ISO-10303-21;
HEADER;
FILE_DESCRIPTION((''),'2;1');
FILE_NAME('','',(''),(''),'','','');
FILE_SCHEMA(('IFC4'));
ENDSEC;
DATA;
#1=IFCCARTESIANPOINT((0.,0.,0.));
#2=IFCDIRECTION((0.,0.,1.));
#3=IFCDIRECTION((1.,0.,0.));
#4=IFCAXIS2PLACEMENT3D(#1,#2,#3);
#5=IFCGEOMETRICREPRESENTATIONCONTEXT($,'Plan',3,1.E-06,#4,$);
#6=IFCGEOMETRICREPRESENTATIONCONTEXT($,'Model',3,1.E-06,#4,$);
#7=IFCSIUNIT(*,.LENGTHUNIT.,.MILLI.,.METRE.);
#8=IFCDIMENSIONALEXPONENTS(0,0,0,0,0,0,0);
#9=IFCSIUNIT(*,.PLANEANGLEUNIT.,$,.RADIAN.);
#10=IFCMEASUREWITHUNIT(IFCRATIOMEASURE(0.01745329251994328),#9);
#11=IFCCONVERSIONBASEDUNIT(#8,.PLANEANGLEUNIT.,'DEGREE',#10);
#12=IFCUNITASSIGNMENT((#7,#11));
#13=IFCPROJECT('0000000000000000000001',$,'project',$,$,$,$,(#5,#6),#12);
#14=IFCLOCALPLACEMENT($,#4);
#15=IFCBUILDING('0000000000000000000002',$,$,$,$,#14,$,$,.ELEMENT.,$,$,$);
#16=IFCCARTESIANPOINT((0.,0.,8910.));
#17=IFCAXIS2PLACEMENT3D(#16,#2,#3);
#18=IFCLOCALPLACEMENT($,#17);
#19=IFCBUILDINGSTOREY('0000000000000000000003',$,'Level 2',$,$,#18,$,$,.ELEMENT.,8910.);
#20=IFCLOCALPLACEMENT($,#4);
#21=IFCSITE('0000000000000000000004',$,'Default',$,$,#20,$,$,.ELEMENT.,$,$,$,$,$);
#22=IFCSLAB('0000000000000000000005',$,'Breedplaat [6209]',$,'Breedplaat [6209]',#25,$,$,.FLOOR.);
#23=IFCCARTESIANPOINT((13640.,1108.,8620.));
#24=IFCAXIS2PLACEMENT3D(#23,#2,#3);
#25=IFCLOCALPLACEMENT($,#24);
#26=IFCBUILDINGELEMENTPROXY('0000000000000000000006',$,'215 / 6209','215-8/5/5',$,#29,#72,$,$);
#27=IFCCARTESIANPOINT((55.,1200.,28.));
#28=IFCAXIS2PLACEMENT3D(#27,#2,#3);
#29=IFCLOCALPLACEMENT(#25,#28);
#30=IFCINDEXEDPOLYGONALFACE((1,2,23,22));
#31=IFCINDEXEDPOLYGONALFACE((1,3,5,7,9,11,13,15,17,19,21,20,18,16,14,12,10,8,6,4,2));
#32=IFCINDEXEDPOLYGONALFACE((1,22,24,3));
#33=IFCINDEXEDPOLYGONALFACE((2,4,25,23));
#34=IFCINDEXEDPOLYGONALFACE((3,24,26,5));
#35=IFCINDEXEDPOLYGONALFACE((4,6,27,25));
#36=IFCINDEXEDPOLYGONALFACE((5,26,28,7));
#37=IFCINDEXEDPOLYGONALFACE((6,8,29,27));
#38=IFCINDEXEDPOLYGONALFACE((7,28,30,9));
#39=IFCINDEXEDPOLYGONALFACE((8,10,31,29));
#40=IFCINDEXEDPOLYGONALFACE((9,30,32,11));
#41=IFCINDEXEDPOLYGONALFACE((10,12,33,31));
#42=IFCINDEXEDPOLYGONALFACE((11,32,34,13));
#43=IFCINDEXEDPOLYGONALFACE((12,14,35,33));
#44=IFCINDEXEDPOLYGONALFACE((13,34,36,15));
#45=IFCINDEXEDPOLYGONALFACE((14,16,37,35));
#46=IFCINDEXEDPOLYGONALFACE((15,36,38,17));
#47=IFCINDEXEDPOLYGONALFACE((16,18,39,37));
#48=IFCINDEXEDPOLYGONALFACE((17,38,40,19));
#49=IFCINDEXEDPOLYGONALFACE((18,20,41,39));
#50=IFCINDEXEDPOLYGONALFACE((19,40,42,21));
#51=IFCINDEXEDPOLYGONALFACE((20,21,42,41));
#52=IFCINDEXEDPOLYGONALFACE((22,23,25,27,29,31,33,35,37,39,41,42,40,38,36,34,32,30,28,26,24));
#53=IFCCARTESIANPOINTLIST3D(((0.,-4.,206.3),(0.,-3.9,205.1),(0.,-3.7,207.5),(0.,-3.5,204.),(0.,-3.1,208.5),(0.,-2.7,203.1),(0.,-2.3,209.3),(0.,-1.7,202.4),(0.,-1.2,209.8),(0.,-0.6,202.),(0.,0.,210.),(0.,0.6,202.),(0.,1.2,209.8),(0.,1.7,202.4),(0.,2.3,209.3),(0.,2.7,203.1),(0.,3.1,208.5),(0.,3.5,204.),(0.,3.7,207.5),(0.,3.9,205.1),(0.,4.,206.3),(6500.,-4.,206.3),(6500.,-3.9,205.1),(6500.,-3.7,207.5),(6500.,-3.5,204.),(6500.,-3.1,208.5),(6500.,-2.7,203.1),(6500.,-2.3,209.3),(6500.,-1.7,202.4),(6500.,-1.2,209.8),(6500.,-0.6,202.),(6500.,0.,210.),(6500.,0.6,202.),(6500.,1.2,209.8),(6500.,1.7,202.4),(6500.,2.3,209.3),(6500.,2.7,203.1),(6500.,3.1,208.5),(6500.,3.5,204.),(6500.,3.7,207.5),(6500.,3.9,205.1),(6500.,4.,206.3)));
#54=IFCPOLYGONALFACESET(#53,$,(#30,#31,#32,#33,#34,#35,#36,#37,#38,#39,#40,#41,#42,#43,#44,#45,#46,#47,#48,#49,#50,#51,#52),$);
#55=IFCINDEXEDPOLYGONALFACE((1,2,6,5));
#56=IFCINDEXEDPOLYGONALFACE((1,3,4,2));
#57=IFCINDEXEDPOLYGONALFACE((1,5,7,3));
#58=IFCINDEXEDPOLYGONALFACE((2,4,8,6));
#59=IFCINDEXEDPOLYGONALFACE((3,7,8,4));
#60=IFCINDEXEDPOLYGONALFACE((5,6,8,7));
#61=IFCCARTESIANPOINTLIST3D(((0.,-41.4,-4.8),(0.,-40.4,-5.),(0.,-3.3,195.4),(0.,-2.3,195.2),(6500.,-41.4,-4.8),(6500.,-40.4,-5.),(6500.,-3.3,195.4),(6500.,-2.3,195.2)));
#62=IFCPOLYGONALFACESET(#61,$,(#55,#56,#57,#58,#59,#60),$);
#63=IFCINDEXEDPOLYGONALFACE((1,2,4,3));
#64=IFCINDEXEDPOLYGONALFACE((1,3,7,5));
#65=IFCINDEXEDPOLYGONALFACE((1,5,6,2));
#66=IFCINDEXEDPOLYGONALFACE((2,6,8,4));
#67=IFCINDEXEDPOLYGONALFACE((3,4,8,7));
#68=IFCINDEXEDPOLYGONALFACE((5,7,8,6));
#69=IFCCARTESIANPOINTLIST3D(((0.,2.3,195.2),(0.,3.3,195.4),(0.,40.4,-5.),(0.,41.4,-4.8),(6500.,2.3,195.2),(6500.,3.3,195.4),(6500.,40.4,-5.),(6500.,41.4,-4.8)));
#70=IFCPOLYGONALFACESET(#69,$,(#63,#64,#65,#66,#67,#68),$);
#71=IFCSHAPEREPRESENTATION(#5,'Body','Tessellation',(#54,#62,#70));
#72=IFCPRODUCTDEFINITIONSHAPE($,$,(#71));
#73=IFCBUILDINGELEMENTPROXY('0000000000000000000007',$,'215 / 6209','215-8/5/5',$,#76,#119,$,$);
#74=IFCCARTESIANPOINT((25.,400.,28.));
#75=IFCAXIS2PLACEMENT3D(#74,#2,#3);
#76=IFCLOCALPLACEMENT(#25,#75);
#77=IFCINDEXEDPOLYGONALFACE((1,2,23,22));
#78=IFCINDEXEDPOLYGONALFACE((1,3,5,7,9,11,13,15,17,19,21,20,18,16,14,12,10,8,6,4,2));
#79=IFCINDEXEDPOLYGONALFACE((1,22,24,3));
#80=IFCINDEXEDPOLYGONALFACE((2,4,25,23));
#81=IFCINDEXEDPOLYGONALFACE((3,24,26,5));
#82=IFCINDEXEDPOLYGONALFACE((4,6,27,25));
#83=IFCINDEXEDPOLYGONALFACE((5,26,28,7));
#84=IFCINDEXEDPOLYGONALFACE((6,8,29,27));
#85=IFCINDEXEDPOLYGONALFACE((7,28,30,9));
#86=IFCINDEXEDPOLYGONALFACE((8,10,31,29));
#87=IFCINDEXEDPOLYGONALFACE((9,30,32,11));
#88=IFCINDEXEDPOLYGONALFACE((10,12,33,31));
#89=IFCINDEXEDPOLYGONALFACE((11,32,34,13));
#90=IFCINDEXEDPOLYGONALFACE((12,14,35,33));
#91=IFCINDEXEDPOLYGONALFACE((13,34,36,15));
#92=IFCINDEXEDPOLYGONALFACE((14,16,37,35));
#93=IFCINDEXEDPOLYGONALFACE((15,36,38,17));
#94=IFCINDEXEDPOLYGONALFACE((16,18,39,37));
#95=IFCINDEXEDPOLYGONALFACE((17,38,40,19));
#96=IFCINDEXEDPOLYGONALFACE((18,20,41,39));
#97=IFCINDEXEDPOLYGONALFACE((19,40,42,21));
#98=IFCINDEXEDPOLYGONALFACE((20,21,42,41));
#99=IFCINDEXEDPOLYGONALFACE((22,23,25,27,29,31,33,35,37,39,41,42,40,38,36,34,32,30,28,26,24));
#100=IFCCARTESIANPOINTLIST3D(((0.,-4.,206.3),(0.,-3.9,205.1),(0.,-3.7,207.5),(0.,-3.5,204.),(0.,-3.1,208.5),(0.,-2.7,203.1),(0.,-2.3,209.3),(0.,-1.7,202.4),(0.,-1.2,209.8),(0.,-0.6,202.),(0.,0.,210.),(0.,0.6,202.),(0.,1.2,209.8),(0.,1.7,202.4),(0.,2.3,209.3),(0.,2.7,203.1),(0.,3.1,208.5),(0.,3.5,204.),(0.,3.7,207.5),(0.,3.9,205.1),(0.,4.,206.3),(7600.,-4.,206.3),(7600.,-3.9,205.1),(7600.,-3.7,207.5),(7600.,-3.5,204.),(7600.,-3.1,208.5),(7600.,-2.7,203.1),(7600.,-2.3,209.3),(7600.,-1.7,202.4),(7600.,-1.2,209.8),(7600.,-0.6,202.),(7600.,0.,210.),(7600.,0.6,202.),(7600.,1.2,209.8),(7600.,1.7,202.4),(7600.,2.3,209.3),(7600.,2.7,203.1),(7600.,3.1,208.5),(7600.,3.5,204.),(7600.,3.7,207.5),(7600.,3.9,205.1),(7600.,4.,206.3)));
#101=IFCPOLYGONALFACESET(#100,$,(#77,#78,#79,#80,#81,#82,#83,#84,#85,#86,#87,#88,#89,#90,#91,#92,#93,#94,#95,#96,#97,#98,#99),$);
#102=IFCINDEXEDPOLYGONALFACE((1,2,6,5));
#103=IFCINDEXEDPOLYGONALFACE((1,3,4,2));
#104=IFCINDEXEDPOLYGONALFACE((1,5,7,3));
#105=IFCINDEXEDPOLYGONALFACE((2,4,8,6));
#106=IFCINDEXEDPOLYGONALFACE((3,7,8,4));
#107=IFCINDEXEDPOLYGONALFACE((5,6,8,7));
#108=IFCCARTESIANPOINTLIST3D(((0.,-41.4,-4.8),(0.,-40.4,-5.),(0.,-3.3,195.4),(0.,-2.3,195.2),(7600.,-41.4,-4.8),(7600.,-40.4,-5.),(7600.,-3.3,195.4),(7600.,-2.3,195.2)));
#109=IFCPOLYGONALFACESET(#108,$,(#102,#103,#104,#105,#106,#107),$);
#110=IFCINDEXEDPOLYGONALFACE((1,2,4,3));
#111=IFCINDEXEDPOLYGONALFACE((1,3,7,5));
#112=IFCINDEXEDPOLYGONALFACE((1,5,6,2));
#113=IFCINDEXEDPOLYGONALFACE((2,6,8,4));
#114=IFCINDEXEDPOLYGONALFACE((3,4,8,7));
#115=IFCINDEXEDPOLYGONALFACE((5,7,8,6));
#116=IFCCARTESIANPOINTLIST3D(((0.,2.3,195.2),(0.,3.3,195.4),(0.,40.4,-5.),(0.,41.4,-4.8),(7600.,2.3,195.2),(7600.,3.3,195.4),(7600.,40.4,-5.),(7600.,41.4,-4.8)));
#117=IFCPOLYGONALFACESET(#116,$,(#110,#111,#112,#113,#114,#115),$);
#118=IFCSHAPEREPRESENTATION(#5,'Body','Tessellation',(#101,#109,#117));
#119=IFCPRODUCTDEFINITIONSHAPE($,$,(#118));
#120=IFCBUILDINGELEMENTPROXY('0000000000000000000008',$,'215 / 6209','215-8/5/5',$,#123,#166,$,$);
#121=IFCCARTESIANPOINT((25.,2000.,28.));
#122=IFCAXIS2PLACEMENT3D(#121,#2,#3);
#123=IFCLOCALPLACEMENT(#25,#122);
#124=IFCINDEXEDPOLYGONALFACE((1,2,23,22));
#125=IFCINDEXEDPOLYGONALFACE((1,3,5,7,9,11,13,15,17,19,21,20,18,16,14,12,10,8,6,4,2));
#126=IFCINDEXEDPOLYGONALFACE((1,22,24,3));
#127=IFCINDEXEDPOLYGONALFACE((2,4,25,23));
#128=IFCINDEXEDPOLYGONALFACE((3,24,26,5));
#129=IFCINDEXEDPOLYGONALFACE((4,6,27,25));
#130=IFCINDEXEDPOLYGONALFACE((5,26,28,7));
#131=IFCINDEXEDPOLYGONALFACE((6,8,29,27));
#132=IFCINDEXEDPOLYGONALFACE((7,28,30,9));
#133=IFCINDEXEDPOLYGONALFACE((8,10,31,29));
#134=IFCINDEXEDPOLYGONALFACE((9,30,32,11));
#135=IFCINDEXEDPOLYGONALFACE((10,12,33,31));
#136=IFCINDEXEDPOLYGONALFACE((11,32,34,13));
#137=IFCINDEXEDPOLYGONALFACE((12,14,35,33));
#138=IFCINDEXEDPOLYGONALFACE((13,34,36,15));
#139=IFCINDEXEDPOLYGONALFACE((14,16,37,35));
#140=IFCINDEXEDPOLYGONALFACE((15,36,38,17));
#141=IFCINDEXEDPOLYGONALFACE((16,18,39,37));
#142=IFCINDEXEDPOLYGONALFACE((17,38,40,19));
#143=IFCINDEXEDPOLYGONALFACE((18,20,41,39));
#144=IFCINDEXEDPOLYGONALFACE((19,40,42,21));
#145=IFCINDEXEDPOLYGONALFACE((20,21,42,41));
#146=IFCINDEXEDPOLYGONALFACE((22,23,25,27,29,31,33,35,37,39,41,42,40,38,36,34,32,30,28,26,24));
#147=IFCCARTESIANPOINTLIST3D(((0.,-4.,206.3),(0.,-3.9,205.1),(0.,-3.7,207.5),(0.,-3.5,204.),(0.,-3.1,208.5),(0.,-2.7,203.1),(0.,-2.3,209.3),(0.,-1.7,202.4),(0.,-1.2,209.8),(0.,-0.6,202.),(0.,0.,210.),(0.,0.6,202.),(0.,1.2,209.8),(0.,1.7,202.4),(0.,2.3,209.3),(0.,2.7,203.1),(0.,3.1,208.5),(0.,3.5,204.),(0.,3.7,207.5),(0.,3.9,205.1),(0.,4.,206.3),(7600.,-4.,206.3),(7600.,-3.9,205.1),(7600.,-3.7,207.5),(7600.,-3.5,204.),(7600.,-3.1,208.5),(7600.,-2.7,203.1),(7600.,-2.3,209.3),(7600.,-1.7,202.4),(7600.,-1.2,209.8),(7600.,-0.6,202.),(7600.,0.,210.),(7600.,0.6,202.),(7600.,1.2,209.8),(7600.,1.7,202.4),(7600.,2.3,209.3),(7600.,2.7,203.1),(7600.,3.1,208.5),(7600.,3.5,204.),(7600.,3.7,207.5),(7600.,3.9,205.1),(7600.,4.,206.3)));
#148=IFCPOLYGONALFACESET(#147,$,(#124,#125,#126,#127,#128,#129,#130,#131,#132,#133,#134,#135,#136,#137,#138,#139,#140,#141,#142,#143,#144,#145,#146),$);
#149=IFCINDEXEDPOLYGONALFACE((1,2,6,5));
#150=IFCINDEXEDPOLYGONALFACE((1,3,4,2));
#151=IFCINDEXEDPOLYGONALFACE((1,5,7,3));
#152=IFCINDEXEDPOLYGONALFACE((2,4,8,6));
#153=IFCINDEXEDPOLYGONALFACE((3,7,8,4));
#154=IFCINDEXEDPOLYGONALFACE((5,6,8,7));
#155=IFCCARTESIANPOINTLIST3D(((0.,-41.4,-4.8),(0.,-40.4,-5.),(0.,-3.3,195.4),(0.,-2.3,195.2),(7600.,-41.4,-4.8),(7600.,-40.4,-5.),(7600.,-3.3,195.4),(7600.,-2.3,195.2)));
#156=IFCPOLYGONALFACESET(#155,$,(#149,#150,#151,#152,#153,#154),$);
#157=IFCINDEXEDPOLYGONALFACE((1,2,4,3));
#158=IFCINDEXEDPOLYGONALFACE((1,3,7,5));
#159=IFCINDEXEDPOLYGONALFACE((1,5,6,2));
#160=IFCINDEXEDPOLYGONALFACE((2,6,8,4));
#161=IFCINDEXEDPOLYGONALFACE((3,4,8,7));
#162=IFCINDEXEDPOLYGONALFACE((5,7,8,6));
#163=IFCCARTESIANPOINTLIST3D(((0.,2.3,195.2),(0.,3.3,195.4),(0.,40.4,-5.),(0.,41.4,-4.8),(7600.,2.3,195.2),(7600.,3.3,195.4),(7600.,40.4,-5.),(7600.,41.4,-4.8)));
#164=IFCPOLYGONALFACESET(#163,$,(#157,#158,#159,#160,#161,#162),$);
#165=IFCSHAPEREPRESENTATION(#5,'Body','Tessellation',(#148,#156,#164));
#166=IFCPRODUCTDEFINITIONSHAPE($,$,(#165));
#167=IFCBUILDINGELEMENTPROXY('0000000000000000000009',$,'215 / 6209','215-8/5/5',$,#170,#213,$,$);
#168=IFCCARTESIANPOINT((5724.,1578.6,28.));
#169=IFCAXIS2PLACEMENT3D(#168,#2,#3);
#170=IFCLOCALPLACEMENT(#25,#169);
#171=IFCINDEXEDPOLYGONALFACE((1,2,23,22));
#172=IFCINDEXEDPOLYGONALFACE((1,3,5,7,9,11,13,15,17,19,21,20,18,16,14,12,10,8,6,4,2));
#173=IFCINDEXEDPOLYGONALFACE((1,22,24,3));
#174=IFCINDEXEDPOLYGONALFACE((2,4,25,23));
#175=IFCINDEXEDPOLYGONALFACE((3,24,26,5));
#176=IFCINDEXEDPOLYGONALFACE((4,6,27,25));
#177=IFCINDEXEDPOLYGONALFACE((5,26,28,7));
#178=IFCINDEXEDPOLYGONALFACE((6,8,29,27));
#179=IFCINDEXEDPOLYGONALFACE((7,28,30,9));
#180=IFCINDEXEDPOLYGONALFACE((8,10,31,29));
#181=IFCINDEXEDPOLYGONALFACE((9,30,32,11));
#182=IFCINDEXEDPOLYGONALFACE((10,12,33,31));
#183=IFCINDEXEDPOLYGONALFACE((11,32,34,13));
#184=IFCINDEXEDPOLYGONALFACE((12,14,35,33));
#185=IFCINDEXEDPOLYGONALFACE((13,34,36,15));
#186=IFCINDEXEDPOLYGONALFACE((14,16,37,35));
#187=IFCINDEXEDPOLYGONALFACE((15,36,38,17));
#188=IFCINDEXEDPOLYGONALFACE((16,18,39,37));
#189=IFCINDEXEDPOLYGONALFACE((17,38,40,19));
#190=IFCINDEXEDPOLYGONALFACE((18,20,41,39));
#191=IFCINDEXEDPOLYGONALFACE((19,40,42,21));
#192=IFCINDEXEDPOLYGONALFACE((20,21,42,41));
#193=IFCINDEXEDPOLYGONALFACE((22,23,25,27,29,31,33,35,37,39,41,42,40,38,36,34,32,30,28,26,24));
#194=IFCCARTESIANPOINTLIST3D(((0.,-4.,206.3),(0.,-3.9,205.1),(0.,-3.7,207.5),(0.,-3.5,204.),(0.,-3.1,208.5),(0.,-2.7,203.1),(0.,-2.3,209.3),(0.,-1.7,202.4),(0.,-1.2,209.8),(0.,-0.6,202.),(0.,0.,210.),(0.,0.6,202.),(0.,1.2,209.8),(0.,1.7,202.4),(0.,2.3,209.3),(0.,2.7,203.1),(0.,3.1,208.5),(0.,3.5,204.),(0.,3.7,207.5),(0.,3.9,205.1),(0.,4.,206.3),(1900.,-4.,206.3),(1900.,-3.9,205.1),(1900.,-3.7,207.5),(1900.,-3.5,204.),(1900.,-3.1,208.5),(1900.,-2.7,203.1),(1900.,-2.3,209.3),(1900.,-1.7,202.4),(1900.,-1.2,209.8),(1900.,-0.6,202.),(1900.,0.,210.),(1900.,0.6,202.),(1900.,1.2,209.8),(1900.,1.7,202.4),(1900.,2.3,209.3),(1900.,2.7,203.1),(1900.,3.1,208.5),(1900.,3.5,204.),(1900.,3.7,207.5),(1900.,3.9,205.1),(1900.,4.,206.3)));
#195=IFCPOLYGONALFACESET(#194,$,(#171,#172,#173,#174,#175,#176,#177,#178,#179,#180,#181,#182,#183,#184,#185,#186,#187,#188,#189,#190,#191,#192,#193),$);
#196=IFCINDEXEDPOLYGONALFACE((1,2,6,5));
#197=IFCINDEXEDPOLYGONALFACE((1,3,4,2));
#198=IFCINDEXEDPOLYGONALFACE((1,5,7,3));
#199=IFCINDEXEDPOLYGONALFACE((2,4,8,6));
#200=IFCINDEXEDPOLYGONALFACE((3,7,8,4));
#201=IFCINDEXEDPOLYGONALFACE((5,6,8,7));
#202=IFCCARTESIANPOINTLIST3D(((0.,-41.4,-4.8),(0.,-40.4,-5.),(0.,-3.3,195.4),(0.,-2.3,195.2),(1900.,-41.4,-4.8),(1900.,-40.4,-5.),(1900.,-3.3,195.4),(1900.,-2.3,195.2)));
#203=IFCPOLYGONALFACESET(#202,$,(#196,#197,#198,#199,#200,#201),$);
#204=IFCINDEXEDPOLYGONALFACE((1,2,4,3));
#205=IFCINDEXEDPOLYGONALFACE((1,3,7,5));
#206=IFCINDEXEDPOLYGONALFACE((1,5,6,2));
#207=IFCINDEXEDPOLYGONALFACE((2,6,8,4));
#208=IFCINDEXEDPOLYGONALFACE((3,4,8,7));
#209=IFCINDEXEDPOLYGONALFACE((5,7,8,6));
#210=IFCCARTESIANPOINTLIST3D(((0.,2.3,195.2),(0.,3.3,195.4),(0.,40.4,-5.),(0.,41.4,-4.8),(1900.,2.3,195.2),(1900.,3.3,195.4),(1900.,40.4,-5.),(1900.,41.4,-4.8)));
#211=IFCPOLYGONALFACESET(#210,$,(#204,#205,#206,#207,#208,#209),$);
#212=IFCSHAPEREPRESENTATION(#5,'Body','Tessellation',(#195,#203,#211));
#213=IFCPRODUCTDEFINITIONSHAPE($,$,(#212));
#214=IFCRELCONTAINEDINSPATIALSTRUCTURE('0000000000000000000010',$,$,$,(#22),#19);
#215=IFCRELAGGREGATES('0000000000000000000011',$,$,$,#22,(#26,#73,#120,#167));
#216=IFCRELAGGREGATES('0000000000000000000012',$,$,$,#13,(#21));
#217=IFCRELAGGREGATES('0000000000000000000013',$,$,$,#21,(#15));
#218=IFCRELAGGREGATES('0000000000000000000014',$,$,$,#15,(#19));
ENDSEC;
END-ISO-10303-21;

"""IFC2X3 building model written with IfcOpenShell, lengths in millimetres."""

from ifc_helpers import new_model, entity, si_unit, converted_unit, frame, origin_with_axes, origin_2d_with_axis, place, context, project, spatial, rectangle, circle, extrude, element, aggregate, save


model = new_model("IFC2X3")

# Units and contexts
plan_context = context("Plan", 3, precision=1e-06, world=origin_with_axes())
model_context = context("Model", 3, precision=1e-06, world=origin_with_axes())
ifc_project = project(units=[si_unit("LENGTHUNIT", "METRE", prefix="MILLI"), converted_unit("PLANEANGLEUNIT", "DEGREE", entity("IfcRatioMeasure", 0.01745329251994328), si_unit("PLANEANGLEUNIT", "RADIAN"), dimensions=[0, 0, 0, 0, 0, 0, 0])], contexts=[plan_context, model_context])

# Site, building, storey
site_placement = place(None, origin_with_axes())
site = spatial("IfcSite", under=ifc_project, at=site_placement, Name="Default", CompositionType="ELEMENT")
building_placement = place(None, origin_with_axes())
building = spatial("IfcBuilding", under=site, at=building_placement, CompositionType="ELEMENT")
storey_placement = place(None, frame((0.0, 0.0, 8910.0), z_axis=(0.0, 0.0, 1.0), x_axis=(1.0, 0.0, 0.0)))
storey = spatial("IfcBuildingStorey", under=building, at=storey_placement, Name="Level 2", CompositionType="ELEMENT", Elevation=8910.0)

# Slab, building element proxies
slab_1_placement = place(None, frame((13640.0, 1108.0, 8620.0), z_axis=(0.0, 0.0, 1.0), x_axis=(1.0, 0.0, 0.0)))
slab_1 = element("IfcSlab", 1, at=slab_1_placement, inside=storey, Name="Breedplaat [6209]", ObjectType="Breedplaat [6209]", PredefinedType="FLOOR")
proxy_1_placement = place(slab_1_placement, frame((55.0, 1200.0, 28.0), z_axis=(0.0, 0.0, 1.0), x_axis=(1.0, 0.0, 0.0)))
proxy_1 = element("IfcBuildingElementProxy", 2, at=proxy_1_placement, Name="215 / 6209", Description="215-8/5/5", context=plan_context, shape_type="SweptSolid", body=[
    extrude(circle(Radius=4.0, at=origin_2d_with_axis()), frame((0.0, 0.0, 206.0), z_axis=(1.0, 0.0, 0.0), x_axis=(0.0, 0.0, 1.0)), (0.0, 0.0, 1.0), 6500.0),
    extrude(rectangle(XDim=203.8, YDim=1.0, at=origin_2d_with_axis()), frame((0.0, -21.9, 95.2), z_axis=(1.0, 0.0, 0.0), x_axis=(0.0, 0.187112, 0.982339)), (0.0, 0.0, 1.0), 6500.0),
    extrude(rectangle(XDim=203.8, YDim=1.0, at=origin_2d_with_axis()), frame((0.0, 21.9, 95.2), z_axis=(1.0, 0.0, 0.0), x_axis=(0.0, -0.187112, 0.982339)), (0.0, 0.0, 1.0), 6500.0),
])
proxy_2_placement = place(slab_1_placement, frame((25.0, 400.0, 28.0), z_axis=(0.0, 0.0, 1.0), x_axis=(1.0, 0.0, 0.0)))
proxy_2 = element("IfcBuildingElementProxy", 3, at=proxy_2_placement, Name="215 / 6209", Description="215-8/5/5", context=plan_context, shape_type="SweptSolid", body=[
    extrude(circle(Radius=4.0, at=origin_2d_with_axis()), frame((0.0, 0.0, 206.0), z_axis=(1.0, 0.0, 0.0), x_axis=(0.0, 0.0, 1.0)), (0.0, 0.0, 1.0), 7600.0),
    extrude(rectangle(XDim=203.8, YDim=1.0, at=origin_2d_with_axis()), frame((0.0, -21.9, 95.2), z_axis=(1.0, 0.0, 0.0), x_axis=(0.0, 0.187112, 0.982339)), (0.0, 0.0, 1.0), 7600.0),
    extrude(rectangle(XDim=203.8, YDim=1.0, at=origin_2d_with_axis()), frame((0.0, 21.9, 95.2), z_axis=(1.0, 0.0, 0.0), x_axis=(0.0, -0.187112, 0.982339)), (0.0, 0.0, 1.0), 7600.0),
])
proxy_3_placement = place(slab_1_placement, frame((25.0, 2000.0, 28.0), z_axis=(0.0, 0.0, 1.0), x_axis=(1.0, 0.0, 0.0)))
proxy_3 = element("IfcBuildingElementProxy", 4, at=proxy_3_placement, Name="215 / 6209", Description="215-8/5/5", context=plan_context, shape_type="SweptSolid", body=[
    extrude(circle(Radius=4.0, at=origin_2d_with_axis()), frame((0.0, 0.0, 206.0), z_axis=(1.0, 0.0, 0.0), x_axis=(0.0, 0.0, 1.0)), (0.0, 0.0, 1.0), 7600.0),
    extrude(rectangle(XDim=203.8, YDim=1.0, at=origin_2d_with_axis()), frame((0.0, -21.9, 95.2), z_axis=(1.0, 0.0, 0.0), x_axis=(0.0, 0.187112, 0.982339)), (0.0, 0.0, 1.0), 7600.0),
    extrude(rectangle(XDim=203.8, YDim=1.0, at=origin_2d_with_axis()), frame((0.0, 21.9, 95.2), z_axis=(1.0, 0.0, 0.0), x_axis=(0.0, -0.187112, 0.982339)), (0.0, 0.0, 1.0), 7600.0),
])
proxy_4_placement = place(slab_1_placement, frame((5724.0, 1578.6, 28.0), z_axis=(0.0, 0.0, 1.0), x_axis=(1.0, 0.0, 0.0)))
proxy_4 = element("IfcBuildingElementProxy", 5, at=proxy_4_placement, Name="215 / 6209", Description="215-8/5/5", context=plan_context, shape_type="SweptSolid", body=[
    extrude(circle(Radius=4.0, at=origin_2d_with_axis()), frame((0.0, 0.0, 206.0), z_axis=(1.0, 0.0, 0.0), x_axis=(0.0, 0.0, 1.0)), (0.0, 0.0, 1.0), 1900.0),
    extrude(rectangle(XDim=203.8, YDim=1.0, at=origin_2d_with_axis()), frame((0.0, -21.9, 95.2), z_axis=(1.0, 0.0, 0.0), x_axis=(0.0, 0.187112, 0.982339)), (0.0, 0.0, 1.0), 1900.0),
    extrude(rectangle(XDim=203.8, YDim=1.0, at=origin_2d_with_axis()), frame((0.0, 21.9, 95.2), z_axis=(1.0, 0.0, 0.0), x_axis=(0.0, -0.187112, 0.982339)), (0.0, 0.0, 1.0), 1900.0),
])
aggregate(slab_1, [proxy_1, proxy_2, proxy_3, proxy_4])

save(model, "model.ifc")
